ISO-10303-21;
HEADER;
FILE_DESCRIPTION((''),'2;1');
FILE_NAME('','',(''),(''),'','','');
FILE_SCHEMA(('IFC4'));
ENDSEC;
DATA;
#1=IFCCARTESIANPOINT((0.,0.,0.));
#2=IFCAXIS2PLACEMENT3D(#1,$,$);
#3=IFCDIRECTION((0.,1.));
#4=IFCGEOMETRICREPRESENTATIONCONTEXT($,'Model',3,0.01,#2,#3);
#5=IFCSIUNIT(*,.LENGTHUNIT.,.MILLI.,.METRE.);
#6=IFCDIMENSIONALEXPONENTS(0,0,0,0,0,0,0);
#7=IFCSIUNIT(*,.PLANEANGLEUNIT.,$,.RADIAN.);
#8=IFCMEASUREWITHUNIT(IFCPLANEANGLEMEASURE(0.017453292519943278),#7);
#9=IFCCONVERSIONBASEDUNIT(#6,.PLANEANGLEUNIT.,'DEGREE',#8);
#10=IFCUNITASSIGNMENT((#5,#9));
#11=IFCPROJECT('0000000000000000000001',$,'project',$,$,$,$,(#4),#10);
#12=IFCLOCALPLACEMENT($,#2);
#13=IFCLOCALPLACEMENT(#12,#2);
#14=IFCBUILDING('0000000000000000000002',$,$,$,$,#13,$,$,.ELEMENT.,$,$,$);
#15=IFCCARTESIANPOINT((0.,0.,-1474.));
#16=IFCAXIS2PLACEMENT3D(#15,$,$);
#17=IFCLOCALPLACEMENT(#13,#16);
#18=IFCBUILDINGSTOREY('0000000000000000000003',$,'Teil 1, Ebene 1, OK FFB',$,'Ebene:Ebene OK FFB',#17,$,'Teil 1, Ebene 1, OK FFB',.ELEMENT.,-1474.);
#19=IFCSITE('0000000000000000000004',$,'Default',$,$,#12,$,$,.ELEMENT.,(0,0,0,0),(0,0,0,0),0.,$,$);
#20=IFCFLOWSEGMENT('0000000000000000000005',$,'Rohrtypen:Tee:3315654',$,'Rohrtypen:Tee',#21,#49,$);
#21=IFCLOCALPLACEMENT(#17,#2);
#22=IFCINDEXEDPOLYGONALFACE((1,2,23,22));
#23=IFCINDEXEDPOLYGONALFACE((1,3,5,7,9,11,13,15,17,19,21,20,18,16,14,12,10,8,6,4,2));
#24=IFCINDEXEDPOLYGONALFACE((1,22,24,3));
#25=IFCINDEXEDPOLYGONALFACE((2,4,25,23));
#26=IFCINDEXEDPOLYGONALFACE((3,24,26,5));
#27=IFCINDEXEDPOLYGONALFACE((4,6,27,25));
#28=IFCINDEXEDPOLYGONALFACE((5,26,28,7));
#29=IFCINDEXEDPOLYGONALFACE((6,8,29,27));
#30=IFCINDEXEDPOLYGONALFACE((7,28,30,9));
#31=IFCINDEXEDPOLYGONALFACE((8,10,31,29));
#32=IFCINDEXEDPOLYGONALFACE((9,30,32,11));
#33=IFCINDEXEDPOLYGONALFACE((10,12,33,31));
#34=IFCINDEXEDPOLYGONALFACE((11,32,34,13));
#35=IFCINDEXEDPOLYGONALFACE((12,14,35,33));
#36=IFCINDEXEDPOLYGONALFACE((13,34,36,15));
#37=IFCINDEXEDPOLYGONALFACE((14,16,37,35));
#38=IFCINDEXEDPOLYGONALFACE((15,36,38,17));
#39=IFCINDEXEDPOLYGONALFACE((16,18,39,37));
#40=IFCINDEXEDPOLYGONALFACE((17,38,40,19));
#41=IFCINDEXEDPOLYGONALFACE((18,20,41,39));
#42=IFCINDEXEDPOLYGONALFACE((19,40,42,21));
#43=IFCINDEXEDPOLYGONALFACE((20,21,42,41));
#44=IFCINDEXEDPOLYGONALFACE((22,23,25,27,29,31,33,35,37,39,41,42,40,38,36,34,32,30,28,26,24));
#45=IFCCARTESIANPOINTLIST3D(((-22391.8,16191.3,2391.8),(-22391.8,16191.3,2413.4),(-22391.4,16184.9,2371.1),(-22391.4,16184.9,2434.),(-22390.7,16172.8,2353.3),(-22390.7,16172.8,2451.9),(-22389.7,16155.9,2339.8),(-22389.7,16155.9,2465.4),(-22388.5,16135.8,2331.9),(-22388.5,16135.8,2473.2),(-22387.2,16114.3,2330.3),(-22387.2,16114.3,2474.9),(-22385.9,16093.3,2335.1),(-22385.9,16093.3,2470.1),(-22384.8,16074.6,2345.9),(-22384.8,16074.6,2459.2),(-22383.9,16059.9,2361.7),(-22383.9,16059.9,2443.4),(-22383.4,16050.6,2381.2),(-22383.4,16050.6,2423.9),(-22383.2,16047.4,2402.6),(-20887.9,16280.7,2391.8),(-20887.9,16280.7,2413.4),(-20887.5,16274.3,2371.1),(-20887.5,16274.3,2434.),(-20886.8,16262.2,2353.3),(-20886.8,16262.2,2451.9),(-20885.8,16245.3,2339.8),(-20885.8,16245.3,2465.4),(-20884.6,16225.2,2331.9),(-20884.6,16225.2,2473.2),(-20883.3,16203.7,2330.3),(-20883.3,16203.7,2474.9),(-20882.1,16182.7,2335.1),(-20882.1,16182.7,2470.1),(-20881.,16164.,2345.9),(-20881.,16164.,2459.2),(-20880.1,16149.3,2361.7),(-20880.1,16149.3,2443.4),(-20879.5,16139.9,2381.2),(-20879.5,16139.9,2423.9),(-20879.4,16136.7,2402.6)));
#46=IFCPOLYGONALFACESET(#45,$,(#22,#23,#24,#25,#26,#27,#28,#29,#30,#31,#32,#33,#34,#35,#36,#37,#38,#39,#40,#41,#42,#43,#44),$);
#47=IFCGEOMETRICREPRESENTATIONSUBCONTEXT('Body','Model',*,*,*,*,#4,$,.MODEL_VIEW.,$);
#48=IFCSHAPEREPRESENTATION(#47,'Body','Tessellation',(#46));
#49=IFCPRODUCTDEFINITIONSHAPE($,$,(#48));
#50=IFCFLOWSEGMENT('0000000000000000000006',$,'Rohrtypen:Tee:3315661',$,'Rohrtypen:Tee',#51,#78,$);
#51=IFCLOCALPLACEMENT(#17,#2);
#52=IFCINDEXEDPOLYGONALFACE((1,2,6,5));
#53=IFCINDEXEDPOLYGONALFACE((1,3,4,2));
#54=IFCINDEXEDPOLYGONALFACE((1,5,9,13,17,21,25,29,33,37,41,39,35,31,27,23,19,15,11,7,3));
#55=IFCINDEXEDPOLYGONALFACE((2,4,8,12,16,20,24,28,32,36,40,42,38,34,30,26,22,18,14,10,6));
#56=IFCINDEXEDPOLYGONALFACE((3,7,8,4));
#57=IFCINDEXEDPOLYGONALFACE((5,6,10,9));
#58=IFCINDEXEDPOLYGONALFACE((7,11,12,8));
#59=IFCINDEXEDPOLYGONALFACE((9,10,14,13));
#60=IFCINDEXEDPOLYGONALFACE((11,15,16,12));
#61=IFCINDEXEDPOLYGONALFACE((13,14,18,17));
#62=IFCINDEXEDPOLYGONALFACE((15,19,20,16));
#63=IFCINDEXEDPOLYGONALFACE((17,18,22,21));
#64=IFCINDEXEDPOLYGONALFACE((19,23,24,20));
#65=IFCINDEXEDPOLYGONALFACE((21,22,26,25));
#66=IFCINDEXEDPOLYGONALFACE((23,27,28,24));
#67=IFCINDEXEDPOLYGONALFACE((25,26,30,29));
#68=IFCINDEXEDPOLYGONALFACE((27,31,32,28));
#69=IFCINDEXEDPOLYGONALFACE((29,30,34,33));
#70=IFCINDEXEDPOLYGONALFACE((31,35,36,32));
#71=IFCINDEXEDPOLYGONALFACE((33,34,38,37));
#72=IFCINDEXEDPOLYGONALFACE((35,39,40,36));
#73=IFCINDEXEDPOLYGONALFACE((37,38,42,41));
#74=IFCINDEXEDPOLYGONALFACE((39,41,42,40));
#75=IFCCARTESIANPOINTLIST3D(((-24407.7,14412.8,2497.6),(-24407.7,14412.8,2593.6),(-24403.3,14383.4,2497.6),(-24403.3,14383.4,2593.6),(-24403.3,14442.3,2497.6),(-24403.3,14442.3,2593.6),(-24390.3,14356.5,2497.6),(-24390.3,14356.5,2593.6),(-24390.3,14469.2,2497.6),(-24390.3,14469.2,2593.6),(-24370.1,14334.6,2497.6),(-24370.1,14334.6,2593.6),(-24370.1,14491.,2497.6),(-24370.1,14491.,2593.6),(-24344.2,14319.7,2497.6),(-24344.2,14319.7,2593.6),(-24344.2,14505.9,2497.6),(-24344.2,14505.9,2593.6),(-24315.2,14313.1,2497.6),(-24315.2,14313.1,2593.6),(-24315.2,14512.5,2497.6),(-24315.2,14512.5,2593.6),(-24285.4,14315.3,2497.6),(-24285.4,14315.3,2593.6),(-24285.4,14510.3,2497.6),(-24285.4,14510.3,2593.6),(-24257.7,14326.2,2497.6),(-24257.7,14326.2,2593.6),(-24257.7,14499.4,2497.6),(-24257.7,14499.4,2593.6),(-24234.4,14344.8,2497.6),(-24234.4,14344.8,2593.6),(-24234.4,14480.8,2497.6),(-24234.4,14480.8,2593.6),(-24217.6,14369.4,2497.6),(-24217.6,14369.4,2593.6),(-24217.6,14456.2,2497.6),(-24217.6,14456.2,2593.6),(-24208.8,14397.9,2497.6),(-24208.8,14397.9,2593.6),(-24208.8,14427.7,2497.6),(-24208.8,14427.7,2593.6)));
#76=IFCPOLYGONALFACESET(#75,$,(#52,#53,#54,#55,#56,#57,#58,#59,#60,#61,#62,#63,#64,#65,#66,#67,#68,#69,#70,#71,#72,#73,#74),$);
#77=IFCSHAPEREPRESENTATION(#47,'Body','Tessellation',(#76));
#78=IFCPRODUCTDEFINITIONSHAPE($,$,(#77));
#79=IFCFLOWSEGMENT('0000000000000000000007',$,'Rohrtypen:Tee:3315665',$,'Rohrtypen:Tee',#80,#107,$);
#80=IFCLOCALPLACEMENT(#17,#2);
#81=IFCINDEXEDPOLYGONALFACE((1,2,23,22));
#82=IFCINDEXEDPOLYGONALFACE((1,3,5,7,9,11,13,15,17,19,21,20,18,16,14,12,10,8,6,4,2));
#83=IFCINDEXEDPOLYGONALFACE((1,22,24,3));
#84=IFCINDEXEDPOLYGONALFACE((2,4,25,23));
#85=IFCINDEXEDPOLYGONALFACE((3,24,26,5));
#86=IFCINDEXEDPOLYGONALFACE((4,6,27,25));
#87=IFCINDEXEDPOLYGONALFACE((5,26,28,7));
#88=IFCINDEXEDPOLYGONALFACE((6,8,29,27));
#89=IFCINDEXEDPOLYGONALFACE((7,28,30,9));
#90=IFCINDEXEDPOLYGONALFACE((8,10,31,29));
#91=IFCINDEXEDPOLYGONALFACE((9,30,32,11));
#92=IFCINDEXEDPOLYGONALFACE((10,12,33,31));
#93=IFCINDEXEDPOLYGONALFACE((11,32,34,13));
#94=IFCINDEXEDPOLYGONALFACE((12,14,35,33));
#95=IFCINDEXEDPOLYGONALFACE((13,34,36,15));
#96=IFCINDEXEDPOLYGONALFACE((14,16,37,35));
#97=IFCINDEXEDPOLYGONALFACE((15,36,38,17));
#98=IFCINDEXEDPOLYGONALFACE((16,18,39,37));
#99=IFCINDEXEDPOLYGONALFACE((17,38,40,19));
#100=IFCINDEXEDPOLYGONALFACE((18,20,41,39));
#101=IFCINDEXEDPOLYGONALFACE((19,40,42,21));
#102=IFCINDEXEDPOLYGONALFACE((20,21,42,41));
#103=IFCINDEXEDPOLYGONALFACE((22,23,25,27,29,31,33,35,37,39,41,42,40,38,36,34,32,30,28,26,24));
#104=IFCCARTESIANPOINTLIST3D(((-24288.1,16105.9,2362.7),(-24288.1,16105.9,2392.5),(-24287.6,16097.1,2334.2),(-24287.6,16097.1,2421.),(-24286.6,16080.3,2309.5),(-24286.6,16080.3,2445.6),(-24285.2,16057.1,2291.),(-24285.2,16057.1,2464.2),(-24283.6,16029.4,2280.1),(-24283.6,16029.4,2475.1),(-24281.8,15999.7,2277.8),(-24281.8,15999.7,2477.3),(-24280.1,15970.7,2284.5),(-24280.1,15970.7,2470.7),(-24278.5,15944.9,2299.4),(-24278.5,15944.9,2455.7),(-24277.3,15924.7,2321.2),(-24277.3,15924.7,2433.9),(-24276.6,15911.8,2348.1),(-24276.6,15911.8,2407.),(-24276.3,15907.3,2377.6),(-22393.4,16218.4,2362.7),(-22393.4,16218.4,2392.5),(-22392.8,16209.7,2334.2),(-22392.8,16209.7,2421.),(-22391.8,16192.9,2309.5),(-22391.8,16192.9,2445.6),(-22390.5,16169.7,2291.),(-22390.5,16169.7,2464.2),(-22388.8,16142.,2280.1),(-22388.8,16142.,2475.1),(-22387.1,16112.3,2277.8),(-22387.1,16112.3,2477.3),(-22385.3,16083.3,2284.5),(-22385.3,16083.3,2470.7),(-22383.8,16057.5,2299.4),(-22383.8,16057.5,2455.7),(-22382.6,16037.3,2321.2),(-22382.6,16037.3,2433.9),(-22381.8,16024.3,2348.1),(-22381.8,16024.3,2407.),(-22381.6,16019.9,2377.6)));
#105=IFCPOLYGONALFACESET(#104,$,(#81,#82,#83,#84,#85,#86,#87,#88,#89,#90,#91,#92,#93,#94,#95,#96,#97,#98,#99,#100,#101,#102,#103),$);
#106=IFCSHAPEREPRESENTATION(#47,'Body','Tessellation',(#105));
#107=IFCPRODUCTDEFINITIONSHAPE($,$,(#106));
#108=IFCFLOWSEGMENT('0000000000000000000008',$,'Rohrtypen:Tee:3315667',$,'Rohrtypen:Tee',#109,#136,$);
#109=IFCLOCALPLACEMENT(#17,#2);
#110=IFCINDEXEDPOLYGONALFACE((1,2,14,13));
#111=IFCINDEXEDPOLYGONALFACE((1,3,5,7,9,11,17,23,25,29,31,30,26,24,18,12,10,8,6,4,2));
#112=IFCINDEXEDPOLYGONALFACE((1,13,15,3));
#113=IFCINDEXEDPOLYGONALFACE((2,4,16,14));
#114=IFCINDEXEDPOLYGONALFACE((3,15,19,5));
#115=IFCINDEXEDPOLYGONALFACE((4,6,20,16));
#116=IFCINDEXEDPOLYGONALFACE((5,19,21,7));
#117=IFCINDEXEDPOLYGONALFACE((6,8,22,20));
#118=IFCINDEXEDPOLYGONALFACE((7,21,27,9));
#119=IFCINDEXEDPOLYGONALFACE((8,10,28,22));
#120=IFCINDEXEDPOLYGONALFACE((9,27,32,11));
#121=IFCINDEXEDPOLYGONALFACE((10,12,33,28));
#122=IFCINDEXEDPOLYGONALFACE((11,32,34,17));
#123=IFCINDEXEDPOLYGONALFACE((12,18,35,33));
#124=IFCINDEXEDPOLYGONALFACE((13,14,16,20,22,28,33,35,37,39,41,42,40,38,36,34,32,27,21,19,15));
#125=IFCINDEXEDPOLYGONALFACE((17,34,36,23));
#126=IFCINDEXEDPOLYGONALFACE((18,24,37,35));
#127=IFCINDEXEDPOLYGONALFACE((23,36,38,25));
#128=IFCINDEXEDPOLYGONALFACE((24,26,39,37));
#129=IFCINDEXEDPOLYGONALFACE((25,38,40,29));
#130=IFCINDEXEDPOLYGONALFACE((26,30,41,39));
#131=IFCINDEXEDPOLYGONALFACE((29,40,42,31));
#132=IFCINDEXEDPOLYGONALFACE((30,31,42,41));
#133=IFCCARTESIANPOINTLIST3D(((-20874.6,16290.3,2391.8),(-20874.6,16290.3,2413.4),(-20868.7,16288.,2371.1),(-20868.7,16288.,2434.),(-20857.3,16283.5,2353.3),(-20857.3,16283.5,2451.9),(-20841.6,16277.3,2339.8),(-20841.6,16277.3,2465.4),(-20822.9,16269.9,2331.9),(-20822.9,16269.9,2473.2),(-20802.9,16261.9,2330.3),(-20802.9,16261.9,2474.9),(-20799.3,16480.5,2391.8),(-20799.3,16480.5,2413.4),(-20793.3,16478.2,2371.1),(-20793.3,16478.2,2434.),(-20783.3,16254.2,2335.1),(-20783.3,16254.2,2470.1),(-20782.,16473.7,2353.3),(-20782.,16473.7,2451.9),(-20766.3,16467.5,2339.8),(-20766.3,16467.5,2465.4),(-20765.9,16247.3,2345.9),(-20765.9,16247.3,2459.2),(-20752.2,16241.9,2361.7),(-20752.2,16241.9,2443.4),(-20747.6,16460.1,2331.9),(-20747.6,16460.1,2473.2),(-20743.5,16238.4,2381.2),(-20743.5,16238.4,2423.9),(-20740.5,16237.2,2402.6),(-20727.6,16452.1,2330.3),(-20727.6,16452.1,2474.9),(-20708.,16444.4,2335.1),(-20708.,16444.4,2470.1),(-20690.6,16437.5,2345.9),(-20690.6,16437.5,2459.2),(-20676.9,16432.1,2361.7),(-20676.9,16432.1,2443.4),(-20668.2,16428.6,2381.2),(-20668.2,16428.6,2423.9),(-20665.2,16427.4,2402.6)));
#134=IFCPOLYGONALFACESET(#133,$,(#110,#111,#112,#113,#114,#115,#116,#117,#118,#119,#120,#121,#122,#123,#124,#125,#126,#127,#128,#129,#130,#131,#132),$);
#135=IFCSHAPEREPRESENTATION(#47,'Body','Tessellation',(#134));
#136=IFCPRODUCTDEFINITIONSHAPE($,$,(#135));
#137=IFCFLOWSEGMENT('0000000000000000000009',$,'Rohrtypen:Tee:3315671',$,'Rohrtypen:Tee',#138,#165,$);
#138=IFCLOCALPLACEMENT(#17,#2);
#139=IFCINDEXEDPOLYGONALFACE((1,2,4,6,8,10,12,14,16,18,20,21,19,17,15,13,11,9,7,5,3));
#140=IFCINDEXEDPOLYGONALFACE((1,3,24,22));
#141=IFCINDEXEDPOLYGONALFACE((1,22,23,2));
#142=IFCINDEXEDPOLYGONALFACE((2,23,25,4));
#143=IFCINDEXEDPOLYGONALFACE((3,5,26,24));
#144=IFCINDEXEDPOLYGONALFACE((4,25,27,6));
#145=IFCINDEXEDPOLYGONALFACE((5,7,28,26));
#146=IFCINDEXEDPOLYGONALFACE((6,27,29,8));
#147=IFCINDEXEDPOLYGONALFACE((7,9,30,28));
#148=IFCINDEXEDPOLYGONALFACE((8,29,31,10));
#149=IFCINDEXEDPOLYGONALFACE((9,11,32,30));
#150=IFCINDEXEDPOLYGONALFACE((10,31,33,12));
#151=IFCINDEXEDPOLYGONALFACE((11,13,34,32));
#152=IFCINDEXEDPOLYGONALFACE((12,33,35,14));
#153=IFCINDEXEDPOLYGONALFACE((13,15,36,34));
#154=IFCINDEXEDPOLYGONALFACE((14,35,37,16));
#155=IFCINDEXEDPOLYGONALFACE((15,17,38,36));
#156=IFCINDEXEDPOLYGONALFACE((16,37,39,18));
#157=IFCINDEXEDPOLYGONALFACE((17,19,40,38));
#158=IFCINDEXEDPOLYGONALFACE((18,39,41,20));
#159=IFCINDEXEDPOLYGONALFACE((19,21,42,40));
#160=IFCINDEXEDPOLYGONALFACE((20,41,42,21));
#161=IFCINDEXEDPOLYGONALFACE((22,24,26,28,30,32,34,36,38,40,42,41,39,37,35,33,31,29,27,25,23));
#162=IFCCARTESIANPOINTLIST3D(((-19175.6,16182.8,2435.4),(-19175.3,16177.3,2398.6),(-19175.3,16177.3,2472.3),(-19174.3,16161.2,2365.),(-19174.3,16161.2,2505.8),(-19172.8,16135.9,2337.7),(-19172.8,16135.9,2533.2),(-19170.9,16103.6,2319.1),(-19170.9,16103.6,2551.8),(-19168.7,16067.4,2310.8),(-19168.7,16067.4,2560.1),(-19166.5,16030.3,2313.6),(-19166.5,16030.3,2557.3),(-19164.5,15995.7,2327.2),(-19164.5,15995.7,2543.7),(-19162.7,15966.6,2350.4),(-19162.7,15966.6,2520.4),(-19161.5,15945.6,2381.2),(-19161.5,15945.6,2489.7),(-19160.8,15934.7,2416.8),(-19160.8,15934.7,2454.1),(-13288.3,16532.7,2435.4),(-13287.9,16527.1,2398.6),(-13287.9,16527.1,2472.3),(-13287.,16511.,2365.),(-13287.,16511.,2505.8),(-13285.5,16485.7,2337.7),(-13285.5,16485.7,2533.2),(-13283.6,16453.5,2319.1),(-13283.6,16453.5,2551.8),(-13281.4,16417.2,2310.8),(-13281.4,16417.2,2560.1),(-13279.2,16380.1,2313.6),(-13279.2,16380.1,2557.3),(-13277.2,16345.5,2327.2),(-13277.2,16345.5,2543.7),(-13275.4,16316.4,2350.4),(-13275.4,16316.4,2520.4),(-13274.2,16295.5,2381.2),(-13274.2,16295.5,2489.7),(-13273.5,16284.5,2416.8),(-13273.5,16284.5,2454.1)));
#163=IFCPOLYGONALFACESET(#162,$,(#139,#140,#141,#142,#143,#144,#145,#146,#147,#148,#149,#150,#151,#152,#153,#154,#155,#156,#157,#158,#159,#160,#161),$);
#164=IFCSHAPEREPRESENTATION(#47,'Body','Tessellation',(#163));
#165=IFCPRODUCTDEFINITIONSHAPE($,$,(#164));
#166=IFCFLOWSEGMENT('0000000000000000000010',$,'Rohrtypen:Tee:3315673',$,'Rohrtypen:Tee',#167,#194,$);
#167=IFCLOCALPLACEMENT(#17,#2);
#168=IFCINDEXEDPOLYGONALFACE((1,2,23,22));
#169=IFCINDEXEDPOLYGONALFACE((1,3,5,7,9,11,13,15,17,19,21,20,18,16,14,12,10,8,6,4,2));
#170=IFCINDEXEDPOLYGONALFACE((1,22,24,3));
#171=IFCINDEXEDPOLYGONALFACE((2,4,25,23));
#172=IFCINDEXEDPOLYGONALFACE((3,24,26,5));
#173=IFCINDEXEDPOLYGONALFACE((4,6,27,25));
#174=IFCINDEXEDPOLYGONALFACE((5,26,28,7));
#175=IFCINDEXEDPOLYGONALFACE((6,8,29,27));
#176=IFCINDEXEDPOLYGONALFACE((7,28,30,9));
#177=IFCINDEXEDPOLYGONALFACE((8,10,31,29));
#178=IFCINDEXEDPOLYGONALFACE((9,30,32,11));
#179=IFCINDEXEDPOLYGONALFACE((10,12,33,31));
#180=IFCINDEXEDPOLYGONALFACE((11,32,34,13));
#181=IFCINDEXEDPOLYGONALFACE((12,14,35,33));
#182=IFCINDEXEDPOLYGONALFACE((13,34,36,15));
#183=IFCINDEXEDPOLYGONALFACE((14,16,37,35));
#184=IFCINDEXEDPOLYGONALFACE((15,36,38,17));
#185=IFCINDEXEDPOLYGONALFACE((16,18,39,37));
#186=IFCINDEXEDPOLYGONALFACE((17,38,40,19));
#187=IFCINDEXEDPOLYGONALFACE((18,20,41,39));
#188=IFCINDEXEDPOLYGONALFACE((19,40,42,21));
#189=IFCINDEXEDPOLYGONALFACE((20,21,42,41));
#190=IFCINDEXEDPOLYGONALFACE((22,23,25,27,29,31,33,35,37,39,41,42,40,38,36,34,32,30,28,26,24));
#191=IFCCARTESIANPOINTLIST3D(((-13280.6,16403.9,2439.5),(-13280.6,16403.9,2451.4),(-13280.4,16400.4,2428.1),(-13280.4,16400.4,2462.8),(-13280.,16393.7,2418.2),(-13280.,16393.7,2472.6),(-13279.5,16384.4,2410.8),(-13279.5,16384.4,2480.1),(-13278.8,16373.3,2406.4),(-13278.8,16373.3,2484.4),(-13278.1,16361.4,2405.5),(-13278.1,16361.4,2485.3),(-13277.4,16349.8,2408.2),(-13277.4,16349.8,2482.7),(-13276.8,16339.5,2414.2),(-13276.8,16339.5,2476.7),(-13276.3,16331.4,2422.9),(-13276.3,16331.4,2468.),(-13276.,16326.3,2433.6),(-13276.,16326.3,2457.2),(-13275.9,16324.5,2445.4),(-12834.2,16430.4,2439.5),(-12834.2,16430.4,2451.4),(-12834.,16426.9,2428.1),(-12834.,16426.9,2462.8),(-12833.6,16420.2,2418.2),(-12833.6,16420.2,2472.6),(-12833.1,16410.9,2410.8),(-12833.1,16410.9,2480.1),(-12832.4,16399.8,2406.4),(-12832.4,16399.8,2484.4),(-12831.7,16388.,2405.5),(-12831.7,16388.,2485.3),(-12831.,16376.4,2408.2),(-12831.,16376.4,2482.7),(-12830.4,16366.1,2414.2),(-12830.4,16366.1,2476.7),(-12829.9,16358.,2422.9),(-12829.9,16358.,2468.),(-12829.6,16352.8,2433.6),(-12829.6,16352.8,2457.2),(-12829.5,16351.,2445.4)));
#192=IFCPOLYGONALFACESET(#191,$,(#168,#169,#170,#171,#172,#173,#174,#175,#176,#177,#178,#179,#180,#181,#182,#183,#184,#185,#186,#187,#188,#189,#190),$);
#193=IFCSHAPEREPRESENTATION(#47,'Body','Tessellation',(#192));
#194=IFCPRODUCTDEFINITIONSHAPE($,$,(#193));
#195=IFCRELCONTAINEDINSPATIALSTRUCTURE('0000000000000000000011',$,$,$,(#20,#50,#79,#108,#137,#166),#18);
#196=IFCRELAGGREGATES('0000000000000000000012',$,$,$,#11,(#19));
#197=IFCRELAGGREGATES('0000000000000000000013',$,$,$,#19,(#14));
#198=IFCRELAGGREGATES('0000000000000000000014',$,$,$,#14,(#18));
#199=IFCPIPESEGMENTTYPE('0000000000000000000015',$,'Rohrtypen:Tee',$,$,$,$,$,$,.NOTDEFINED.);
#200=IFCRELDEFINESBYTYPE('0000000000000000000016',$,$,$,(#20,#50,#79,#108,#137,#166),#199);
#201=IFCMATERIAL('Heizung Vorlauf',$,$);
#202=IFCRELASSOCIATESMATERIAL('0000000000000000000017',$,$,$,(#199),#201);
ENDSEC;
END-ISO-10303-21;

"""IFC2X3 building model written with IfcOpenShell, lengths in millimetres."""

from ifc_helpers import new_model, entity, si_unit, converted_unit, direction, frame, frame_2d, origin, origin_2d_with_axis, place, context, subcontext, project, spatial, circle, extrude, material, type_object, element, save


model = new_model("IFC2X3")

# Units and contexts
model_context = context("Model", 3, precision=0.01, world=origin(), true_north=direction((0.0, 1.0)))
body_context = subcontext(model_context, "Body", "Model", "MODEL_VIEW")
ifc_project = project(units=[si_unit("LENGTHUNIT", "METRE", prefix="MILLI"), converted_unit("PLANEANGLEUNIT", "DEGREE", entity("IfcPlaneAngleMeasure", 0.017453292519943278), si_unit("PLANEANGLEUNIT", "RADIAN"), dimensions=[0, 0, 0, 0, 0, 0, 0])], contexts=[model_context])

# Site, building, storey
site_placement = place(None, origin())
site = spatial("IfcSite", under=ifc_project, at=site_placement, Name="Default", CompositionType="ELEMENT", RefLatitude=(0, 0, 0, 0), RefLongitude=(0, 0, 0, 0), RefElevation=0.0)
building_placement = place(site_placement, origin())
building = spatial("IfcBuilding", under=site, at=building_placement, CompositionType="ELEMENT")
storey_placement = place(building_placement, frame((0.0, 0.0, -1474.0)))
storey = spatial("IfcBuildingStorey", under=building, at=storey_placement, Name="Teil 1, Ebene 1, OK FFB", ObjectType="Ebene:Ebene OK FFB", LongName="Teil 1, Ebene 1, OK FFB", CompositionType="ELEMENT", Elevation=-1474.0)

# Flow segments
ifc_material = material(Name="Heizung Vorlauf")
pipe_segment_type = type_object("IfcPipeSegmentType", Name="Rohrtypen:Tee", PredefinedType="NOTDEFINED", material=ifc_material)
flow_segment_1_placement = place(storey_placement, origin())
element("IfcFlowSegment", 1, at=flow_segment_1_placement, inside=storey, type_object=pipe_segment_type, Name="Rohrtypen:Tee:3315654", ObjectType="Rohrtypen:Tee", context=body_context, shape_type="SweptSolid", body=[
    extrude(circle(Radius=72.5, at=origin_2d_with_axis()), frame((-22387.5, 16119.7, 2402.6), z_axis=(0.998239, 0.059319, 0.0), x_axis=(0.059319, -0.998239, 0.0)), (0.0, 0.0, 1.0), 1506.5),
])
flow_segment_2_placement = place(storey_placement, origin())
element("IfcFlowSegment", 2, at=flow_segment_2_placement, inside=storey, type_object=pipe_segment_type, Name="Rohrtypen:Tee:3315661", ObjectType="Rohrtypen:Tee", context=body_context, shape_type="SweptSolid", body=[
    extrude(circle(Radius=100.0, at=frame_2d((0.0, 0.0), x_axis=(1.0, 0.0))), frame((-24307.7, 14412.8, 2497.6), z_axis=(0.0, 0.0, 1.0), x_axis=(-1.0, 0.0, 0.0)), (0.0, 0.0, 1.0), 96.1),
])
flow_segment_3_placement = place(storey_placement, origin())
element("IfcFlowSegment", 3, at=flow_segment_3_placement, inside=storey, type_object=pipe_segment_type, Name="Rohrtypen:Tee:3315665", ObjectType="Rohrtypen:Tee", context=body_context, shape_type="SweptSolid", body=[
    extrude(circle(Radius=100.0, at=origin_2d_with_axis()), frame((-24282.2, 16007.1, 2377.6), z_axis=(0.998239, 0.059319, 0.0), x_axis=(0.059319, -0.998239, 0.0)), (0.0, 0.0, 1.0), 1898.1),
])
flow_segment_4_placement = place(storey_placement, origin())
element("IfcFlowSegment", 4, at=flow_segment_4_placement, inside=storey, type_object=pipe_segment_type, Name="Rohrtypen:Tee:3315667", ObjectType="Rohrtypen:Tee", context=body_context, shape_type="SweptSolid", body=[
    extrude(circle(Radius=72.5, at=origin_2d_with_axis()), frame((-20807.9, 16263.9, 2402.6), z_axis=(0.368112, 0.929781, 0.0), x_axis=(0.929781, -0.368112, 0.0)), (0.0, 0.0, 1.0), 204.6),
])
flow_segment_5_placement = place(storey_placement, origin())
element("IfcFlowSegment", 5, at=flow_segment_5_placement, inside=storey, type_object=pipe_segment_type, Name="Rohrtypen:Tee:3315671", ObjectType="Rohrtypen:Tee", context=body_context, shape_type="SweptSolid", body=[
    extrude(circle(Radius=125.0, at=origin_2d_with_axis()), frame((-19168.2, 16058.1, 2435.4), z_axis=(0.998239, 0.059319, 0.0), x_axis=(-0.059319, 0.998239, 0.0)), (0.0, 0.0, 1.0), 5897.7),
])
flow_segment_6_placement = place(storey_placement, origin())
element("IfcFlowSegment", 6, at=flow_segment_6_placement, inside=storey, type_object=pipe_segment_type, Name="Rohrtypen:Tee:3315673", ObjectType="Rohrtypen:Tee", context=body_context, shape_type="SweptSolid", body=[
    extrude(circle(Radius=40.0, at=origin_2d_with_axis()), frame((-13278.3, 16364.4, 2445.4), z_axis=(0.998239, 0.059319, 0.0), x_axis=(0.059319, -0.998239, 0.0)), (0.0, 0.0, 1.0), 447.2),
])

save(model, "model.ifc")
